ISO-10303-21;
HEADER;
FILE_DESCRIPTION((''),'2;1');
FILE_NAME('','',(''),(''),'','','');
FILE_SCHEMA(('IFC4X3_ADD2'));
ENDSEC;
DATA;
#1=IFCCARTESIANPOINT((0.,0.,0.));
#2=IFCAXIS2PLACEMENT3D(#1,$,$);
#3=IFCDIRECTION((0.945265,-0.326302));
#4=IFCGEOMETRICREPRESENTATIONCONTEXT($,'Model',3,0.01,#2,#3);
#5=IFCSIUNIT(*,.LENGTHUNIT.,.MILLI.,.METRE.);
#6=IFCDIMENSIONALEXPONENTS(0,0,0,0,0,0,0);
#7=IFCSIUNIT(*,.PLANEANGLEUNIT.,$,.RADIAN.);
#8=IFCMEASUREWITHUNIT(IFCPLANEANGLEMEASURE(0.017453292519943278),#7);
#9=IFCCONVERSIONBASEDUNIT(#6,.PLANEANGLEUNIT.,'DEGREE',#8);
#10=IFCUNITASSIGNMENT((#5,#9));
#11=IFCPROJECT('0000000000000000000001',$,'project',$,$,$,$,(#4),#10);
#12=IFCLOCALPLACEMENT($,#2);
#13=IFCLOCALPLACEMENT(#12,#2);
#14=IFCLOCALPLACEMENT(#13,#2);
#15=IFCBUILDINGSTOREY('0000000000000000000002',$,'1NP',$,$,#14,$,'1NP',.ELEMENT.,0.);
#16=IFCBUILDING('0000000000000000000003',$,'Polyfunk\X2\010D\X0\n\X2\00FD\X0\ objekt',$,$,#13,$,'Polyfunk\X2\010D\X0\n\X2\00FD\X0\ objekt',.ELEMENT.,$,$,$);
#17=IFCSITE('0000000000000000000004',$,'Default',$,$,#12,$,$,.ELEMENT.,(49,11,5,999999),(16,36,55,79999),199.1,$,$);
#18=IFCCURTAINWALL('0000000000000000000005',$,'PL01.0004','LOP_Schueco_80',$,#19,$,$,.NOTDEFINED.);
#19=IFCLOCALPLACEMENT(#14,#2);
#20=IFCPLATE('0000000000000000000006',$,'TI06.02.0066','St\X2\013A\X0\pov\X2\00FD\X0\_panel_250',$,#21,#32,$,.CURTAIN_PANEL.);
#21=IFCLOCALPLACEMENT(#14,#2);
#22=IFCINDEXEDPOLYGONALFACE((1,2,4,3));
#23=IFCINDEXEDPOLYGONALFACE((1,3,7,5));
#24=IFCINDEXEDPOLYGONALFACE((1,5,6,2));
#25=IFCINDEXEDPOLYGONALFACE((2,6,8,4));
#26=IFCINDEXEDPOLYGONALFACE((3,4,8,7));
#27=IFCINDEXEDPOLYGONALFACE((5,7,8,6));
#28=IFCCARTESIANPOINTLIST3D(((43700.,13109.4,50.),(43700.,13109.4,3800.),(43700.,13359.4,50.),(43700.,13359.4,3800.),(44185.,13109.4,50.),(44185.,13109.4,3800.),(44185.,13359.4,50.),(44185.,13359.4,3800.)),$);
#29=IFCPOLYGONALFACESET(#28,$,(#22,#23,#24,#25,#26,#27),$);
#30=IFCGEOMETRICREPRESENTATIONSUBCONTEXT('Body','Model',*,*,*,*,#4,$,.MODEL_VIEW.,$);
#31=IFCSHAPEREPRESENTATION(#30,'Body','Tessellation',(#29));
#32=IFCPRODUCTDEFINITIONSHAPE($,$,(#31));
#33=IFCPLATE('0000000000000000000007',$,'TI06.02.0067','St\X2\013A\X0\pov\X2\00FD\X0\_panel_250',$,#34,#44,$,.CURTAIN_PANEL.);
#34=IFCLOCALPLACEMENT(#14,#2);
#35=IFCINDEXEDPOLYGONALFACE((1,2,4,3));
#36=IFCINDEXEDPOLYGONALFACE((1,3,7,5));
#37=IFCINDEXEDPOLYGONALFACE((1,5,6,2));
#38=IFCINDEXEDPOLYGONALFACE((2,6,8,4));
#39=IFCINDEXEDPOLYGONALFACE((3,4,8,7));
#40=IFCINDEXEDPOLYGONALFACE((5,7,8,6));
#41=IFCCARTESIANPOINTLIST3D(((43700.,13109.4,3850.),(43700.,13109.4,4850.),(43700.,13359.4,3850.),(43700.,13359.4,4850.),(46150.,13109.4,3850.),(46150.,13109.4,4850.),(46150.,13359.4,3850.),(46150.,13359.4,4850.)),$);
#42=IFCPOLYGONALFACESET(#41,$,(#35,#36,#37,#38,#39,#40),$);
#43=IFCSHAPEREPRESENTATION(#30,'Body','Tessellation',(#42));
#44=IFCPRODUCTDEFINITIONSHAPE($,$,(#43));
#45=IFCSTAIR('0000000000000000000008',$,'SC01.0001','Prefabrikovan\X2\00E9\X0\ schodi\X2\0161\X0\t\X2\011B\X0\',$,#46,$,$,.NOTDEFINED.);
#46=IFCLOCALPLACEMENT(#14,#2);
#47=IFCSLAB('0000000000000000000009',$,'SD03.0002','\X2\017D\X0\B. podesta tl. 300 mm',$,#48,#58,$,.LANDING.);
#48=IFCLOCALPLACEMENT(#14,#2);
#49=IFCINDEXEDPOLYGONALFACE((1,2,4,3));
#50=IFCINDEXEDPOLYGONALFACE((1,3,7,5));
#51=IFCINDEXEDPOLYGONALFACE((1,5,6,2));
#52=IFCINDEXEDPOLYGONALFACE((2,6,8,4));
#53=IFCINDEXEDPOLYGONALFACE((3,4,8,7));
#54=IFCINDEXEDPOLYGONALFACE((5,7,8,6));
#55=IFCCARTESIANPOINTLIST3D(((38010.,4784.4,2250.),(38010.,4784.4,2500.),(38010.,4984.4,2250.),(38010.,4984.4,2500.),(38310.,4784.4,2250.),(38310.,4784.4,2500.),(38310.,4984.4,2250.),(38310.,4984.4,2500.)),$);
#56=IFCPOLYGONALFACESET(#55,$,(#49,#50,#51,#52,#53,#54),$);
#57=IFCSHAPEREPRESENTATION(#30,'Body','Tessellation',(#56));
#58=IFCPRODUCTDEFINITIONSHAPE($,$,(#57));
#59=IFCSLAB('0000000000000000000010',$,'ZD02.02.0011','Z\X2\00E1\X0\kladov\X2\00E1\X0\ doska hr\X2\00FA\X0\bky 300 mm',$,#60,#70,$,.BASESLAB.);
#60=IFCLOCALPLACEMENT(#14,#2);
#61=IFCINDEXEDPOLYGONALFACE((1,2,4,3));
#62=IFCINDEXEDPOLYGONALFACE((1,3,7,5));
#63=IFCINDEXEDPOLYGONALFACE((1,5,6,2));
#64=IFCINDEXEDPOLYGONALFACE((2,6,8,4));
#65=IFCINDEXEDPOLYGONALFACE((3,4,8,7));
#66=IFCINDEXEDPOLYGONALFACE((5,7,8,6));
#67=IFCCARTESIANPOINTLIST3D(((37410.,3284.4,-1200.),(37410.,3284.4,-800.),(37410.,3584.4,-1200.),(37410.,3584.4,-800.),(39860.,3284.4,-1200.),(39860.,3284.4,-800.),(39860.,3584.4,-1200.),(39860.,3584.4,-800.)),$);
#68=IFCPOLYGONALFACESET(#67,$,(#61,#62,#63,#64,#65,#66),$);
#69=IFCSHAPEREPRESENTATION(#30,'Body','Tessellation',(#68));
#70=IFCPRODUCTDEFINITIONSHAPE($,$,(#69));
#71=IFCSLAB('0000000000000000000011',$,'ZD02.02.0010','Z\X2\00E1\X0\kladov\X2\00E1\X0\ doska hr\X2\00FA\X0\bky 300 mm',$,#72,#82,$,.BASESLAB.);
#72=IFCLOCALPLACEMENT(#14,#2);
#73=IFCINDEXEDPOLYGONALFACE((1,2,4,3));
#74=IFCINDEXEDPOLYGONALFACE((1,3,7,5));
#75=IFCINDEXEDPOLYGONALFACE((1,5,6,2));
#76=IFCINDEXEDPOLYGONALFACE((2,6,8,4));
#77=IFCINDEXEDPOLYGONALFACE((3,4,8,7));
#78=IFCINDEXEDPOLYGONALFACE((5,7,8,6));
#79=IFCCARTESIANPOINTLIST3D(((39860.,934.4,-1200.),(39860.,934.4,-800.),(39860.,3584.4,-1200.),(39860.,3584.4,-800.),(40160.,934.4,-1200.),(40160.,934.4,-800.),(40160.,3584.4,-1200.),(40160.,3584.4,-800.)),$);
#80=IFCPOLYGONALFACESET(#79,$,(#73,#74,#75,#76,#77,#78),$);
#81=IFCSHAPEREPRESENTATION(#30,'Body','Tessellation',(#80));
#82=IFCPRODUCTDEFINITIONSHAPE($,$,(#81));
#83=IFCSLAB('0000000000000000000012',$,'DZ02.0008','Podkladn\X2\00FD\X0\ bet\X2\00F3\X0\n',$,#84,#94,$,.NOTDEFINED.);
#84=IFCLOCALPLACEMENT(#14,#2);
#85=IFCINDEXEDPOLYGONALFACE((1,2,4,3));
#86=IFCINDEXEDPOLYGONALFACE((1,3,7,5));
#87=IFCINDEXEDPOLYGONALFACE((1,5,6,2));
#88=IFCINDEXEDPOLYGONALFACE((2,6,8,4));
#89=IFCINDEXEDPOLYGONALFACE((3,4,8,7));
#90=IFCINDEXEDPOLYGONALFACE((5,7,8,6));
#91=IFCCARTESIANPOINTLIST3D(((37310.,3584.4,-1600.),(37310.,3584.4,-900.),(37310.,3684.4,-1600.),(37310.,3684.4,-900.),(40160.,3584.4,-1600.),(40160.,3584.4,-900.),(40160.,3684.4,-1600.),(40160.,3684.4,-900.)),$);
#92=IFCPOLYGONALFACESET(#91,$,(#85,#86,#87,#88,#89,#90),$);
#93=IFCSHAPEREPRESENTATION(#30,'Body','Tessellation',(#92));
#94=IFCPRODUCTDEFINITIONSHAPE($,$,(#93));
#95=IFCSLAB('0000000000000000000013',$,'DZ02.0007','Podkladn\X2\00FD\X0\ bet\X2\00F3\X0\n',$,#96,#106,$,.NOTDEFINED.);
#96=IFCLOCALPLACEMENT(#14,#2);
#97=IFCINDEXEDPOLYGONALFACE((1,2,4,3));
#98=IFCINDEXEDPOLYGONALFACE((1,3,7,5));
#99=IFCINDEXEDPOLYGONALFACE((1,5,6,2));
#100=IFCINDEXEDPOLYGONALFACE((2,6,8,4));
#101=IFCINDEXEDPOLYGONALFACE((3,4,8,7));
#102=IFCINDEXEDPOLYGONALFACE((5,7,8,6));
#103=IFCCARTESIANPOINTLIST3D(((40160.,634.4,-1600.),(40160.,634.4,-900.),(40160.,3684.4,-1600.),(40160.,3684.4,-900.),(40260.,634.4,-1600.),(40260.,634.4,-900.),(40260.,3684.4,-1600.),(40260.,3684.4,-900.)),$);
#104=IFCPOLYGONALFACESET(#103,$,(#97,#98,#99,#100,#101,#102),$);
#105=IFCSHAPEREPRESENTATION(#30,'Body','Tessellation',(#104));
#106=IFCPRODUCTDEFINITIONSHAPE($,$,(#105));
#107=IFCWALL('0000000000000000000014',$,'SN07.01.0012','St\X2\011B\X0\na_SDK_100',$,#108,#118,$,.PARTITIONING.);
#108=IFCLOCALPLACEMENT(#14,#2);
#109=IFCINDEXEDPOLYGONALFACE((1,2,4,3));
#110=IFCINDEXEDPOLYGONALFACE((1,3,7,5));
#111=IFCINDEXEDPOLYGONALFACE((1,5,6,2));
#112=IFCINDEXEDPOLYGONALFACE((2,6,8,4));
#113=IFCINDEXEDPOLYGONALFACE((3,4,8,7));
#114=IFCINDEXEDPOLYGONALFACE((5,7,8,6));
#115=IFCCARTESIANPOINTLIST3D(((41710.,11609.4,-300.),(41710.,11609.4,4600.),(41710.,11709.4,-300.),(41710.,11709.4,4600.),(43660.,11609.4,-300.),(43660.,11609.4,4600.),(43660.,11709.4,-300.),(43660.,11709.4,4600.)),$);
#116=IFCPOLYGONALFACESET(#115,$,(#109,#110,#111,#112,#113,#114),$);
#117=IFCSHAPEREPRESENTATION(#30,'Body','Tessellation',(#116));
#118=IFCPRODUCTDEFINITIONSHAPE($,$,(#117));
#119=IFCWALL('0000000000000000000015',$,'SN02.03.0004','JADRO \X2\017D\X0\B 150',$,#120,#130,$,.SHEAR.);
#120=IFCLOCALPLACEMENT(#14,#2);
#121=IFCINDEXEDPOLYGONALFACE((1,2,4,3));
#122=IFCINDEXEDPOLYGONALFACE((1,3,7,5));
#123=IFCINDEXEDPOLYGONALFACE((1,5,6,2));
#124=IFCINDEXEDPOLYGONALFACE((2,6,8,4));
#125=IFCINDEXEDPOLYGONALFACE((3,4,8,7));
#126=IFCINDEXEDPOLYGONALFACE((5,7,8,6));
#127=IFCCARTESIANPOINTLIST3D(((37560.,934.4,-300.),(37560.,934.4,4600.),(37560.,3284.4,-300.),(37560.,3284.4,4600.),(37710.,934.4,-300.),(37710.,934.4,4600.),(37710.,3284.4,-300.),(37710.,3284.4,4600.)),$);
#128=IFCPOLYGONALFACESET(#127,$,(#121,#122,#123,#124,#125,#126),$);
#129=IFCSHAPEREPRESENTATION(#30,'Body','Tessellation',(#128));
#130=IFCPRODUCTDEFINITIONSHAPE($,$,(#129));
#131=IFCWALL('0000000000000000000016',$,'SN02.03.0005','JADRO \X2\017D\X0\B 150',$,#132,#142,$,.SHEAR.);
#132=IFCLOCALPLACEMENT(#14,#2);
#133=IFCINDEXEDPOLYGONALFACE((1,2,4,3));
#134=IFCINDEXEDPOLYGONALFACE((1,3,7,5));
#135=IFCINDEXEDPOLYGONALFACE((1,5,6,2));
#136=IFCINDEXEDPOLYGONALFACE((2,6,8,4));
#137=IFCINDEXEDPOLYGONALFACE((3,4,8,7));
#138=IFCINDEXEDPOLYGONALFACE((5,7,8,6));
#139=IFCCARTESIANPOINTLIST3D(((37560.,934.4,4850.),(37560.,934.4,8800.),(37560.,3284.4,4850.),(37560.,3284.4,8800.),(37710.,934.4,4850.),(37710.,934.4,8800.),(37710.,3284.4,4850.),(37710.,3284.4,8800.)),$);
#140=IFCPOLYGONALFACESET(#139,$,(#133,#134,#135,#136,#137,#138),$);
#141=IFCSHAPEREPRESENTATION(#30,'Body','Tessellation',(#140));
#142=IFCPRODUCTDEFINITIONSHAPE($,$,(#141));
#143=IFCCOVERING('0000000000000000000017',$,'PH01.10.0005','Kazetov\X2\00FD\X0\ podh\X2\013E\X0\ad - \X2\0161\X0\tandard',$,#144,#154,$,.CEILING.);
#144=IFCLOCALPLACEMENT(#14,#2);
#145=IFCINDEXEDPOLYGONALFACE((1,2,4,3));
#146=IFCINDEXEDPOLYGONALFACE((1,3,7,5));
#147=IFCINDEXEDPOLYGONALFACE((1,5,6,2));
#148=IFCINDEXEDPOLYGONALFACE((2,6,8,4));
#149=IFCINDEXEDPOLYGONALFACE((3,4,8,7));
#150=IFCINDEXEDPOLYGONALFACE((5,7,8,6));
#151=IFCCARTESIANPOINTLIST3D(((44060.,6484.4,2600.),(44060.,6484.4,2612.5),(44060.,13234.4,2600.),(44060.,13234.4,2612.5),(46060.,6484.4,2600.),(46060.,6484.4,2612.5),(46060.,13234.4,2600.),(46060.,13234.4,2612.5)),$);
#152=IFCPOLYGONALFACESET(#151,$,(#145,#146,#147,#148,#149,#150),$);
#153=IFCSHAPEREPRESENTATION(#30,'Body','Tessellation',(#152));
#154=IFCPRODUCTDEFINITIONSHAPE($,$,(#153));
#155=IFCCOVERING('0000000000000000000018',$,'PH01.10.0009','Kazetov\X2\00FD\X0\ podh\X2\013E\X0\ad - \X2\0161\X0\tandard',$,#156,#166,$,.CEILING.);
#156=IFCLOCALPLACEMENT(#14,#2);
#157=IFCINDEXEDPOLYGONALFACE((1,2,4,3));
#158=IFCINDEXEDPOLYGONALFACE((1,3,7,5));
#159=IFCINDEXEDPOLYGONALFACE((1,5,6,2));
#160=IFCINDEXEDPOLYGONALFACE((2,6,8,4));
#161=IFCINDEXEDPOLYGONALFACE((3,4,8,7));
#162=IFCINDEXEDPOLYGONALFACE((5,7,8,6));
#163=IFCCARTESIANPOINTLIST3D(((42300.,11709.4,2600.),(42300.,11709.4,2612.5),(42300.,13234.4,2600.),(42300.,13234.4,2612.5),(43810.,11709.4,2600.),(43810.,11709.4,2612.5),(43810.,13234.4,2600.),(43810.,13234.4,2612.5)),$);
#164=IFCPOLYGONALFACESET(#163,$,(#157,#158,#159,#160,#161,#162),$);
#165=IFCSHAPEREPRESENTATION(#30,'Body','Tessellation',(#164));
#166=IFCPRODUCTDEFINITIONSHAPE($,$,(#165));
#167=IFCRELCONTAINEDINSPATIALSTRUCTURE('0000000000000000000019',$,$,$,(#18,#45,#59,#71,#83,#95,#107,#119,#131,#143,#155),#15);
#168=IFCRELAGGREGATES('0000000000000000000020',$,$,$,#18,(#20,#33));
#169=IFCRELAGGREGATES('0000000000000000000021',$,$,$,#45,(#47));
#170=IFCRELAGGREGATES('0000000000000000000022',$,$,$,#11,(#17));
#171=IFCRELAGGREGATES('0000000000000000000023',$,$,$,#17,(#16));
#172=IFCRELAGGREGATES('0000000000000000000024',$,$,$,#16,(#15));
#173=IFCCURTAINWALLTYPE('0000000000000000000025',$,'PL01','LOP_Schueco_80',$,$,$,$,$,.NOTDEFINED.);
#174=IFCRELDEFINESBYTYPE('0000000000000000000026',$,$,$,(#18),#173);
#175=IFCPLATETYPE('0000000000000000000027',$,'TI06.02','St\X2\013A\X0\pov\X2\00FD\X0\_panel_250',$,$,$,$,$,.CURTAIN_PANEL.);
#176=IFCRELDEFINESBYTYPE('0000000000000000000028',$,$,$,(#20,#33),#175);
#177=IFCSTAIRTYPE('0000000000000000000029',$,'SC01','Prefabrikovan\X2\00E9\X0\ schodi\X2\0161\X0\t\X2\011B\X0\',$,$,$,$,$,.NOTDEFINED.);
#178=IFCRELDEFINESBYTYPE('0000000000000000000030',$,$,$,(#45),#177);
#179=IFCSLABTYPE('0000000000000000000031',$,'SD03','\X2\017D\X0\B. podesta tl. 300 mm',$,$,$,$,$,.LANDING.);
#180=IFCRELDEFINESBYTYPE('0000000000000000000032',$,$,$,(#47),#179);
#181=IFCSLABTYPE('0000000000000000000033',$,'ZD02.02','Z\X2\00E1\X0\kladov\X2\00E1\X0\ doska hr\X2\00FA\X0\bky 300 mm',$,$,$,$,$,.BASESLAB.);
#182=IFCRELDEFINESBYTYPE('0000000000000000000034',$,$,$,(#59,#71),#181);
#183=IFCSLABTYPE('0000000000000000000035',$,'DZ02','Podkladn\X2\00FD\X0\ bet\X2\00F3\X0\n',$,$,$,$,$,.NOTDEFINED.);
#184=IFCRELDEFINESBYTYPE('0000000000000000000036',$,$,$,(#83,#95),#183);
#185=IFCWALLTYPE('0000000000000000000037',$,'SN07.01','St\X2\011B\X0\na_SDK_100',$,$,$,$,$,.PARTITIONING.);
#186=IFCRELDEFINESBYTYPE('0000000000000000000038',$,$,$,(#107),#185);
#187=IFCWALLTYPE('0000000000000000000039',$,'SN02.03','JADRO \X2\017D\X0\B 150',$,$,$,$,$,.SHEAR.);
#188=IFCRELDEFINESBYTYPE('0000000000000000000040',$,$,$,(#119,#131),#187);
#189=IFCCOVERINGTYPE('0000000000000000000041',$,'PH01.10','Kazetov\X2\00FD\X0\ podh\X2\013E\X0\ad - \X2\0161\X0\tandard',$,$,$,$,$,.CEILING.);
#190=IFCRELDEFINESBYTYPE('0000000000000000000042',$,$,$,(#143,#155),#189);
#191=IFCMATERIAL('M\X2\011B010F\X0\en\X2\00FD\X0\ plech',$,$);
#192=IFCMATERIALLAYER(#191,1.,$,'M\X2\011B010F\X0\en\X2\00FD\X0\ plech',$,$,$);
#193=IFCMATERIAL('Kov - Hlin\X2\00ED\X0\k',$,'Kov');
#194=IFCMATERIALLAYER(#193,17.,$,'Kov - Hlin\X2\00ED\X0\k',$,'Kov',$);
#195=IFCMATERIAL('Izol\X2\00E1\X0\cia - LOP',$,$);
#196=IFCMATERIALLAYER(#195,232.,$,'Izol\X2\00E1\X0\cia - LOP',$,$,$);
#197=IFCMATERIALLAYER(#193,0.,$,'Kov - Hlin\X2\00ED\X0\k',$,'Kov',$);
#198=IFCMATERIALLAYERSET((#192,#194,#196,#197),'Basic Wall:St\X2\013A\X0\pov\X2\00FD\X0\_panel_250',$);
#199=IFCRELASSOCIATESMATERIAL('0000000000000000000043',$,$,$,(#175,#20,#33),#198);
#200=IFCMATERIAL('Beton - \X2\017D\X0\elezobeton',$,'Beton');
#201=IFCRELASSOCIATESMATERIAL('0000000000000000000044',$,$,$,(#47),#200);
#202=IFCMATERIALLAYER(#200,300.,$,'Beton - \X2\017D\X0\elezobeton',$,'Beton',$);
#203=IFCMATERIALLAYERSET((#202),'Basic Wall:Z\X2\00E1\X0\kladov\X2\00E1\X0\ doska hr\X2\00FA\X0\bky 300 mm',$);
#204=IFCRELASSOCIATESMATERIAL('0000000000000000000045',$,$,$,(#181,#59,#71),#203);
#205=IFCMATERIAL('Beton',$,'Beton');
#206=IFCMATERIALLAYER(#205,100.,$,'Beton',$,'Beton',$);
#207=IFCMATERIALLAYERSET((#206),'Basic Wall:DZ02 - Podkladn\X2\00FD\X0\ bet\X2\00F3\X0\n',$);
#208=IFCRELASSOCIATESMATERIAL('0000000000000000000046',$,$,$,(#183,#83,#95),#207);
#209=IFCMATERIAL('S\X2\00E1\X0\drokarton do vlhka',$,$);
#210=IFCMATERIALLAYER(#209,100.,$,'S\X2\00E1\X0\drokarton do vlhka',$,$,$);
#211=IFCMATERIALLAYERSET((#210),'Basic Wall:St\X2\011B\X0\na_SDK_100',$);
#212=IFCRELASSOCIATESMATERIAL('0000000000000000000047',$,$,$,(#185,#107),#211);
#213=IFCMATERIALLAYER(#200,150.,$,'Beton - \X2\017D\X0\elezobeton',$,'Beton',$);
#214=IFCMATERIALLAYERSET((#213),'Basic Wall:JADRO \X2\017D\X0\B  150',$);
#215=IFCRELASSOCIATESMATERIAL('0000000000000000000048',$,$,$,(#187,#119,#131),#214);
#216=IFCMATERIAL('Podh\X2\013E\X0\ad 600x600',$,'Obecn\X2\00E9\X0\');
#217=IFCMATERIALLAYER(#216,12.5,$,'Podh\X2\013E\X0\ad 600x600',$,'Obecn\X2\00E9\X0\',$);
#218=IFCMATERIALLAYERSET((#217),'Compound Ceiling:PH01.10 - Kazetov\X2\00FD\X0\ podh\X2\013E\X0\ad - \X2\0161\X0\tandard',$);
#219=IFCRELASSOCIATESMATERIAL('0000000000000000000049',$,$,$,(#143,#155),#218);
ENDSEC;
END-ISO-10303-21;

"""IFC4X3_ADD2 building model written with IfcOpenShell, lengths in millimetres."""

from ifc_helpers import new_model, entity, si_unit, converted_unit, direction, frame, frame_2d, origin, place, context, subcontext, project, spatial, polyline, rectangle, extrude, clip, bounded_halfspace, material, layer, layer_set, layer_usage, type_object, element, aggregate, save


model = new_model("IFC4X3_ADD2")

# Units and contexts
model_context = context("Model", 3, precision=0.01, world=origin(), true_north=direction((0.945265, -0.326302)))
body_context = subcontext(model_context, "Body", "Model", "MODEL_VIEW")
ifc_project = project(units=[si_unit("LENGTHUNIT", "METRE", prefix="MILLI"), converted_unit("PLANEANGLEUNIT", "DEGREE", entity("IfcPlaneAngleMeasure", 0.017453292519943278), si_unit("PLANEANGLEUNIT", "RADIAN"), dimensions=[0, 0, 0, 0, 0, 0, 0])], contexts=[model_context])

# Site, building, storey
site_placement = place(None, origin())
site = spatial("IfcSite", under=ifc_project, at=site_placement, Name="Default", CompositionType="ELEMENT", RefLatitude=(49, 11, 5, 999999), RefLongitude=(16, 36, 55, 79999), RefElevation=199.1)
building_placement = place(site_placement, origin())
building = spatial("IfcBuilding", under=site, at=building_placement, Name="Polyfunkčný objekt", LongName="Polyfunkčný objekt", CompositionType="ELEMENT")
storey_placement = place(building_placement, origin())
storey = spatial("IfcBuildingStorey", under=building, at=storey_placement, Name="1NP", LongName="1NP", CompositionType="ELEMENT", Elevation=0.0)

# Curtain wall, plates
curtain_wall_type = type_object("IfcCurtainWallType", Name="PL01", Description="LOP_Schueco_80", PredefinedType="NOTDEFINED")
curtain_wall_placement = place(storey_placement, origin())
curtain_wall = element("IfcCurtainWall", 1, at=curtain_wall_placement, inside=storey, type_object=curtain_wall_type, Name="PL01.0004", Description="LOP_Schueco_80", PredefinedType="NOTDEFINED")
ifc_material_1 = material(Name="Měďený plech")
ifc_layer_1 = layer(ifc_material_1, 1.0, Name="Měďený plech")
ifc_material_2 = material(Name="Kov - Hliník", Category="Kov")
ifc_layer_2 = layer(ifc_material_2, 17.0, Name="Kov - Hliník", Category="Kov")
ifc_material_3 = material(Name="Izolácia - LOP")
ifc_layer_3 = layer(ifc_material_3, 232.0, Name="Izolácia - LOP")
ifc_layer_4 = layer(ifc_material_2, 0.0, Name="Kov - Hliník", Category="Kov")
ifc_layer_set_1 = layer_set([ifc_layer_1, ifc_layer_2, ifc_layer_3, ifc_layer_4], Name="Basic Wall:Stĺpový_panel_250")
ifc_layer_usage_1 = layer_usage(ifc_layer_set_1, "AXIS2", "NEGATIVE", 125.0)
plate_type = type_object("IfcPlateType", Name="TI06.02", Description="Stĺpový_panel_250", PredefinedType="CURTAIN_PANEL", material=ifc_layer_set_1)
plate_1_placement = place(storey_placement, frame((43700.0, 13234.4, 50.0)))
plate_1 = element("IfcPlate", 2, at=plate_1_placement, type_object=plate_type, material=ifc_layer_usage_1, Name="TI06.02.0066", Description="Stĺpový_panel_250", PredefinedType="CURTAIN_PANEL", context=body_context, shape_type="SweptSolid", body=[
    extrude(rectangle(XDim=250.0, YDim=485.0, at=frame_2d((0.0, 0.0), x_axis=(1.0, 0.0))), frame((242.5, 0.0, 0.0), z_axis=(0.0, 0.0, 1.0), x_axis=(0.0, 1.0, 0.0)), (0.0, 0.0, 1.0), 3750.0),
])
ifc_layer_usage_2 = layer_usage(ifc_layer_set_1, "AXIS2", "NEGATIVE", 125.0)
plate_2_placement = place(storey_placement, frame((43700.0, 13234.4, 3850.0)))
plate_2 = element("IfcPlate", 3, at=plate_2_placement, type_object=plate_type, material=ifc_layer_usage_2, Name="TI06.02.0067", Description="Stĺpový_panel_250", PredefinedType="CURTAIN_PANEL", context=body_context, shape_type="SweptSolid", body=[
    extrude(rectangle(XDim=250.0, YDim=2450.0, at=frame_2d((0.0, 0.0), x_axis=(1.0, 0.0))), frame((1225.0, 0.0, 0.0), z_axis=(0.0, 0.0, 1.0), x_axis=(0.0, 1.0, 0.0)), (0.0, 0.0, 1.0), 1000.0),
])
aggregate(curtain_wall, [plate_1, plate_2])

# Stair, slab
stair_type = type_object("IfcStairType", Name="SC01", Description="Prefabrikované schodiště", PredefinedType="NOTDEFINED")
stair_placement = place(storey_placement, origin())
stair = element("IfcStair", 4, at=stair_placement, inside=storey, type_object=stair_type, Name="SC01.0001", Description="Prefabrikované schodiště", PredefinedType="NOTDEFINED")
ifc_material_4 = material(Name="Beton - Železobeton", Category="Beton")
slab_type_1 = type_object("IfcSlabType", Name="SD03", Description="ŽB. podesta tl. 300 mm", PredefinedType="LANDING")
slab_1_placement = place(stair_placement, frame((38010.0, 4784.4, 0.0)))
slab_1 = element("IfcSlab", 5, at=slab_1_placement, type_object=slab_type_1, material=ifc_material_4, Name="SD03.0002", Description="ŽB. podesta tl. 300 mm", PredefinedType="LANDING", context=body_context, shape_type="SweptSolid", body=[
    extrude(rectangle(XDim=200.0, YDim=300.0, at=frame_2d((0.0, 0.0), x_axis=(1.0, 0.0))), frame((150.0, 100.0, 2250.0), z_axis=(0.0, 0.0, 1.0), x_axis=(0.0, 1.0, 0.0)), (0.0, 0.0, 1.0), 250.0),
])
aggregate(stair, [slab_1])

# Slabs
ifc_layer_5 = layer(ifc_material_4, 300.0, Name="Beton - Železobeton", Category="Beton")
ifc_layer_set_2 = layer_set([ifc_layer_5], Name="Basic Wall:Základová doska hrúbky 300 mm")
slab_type_2 = type_object("IfcSlabType", Name="ZD02.02", Description="Základová doska hrúbky 300 mm", PredefinedType="BASESLAB", material=ifc_layer_set_2)
slab_2_placement = place(storey_placement, frame((37410.0, 3434.4, -1200.0)))
element("IfcSlab", 6, at=slab_2_placement, inside=storey, type_object=slab_type_2, material=ifc_layer_set_2, Name="ZD02.02.0011", Description="Základová doska hrúbky 300 mm", PredefinedType="BASESLAB", context=body_context, shape_type="SweptSolid", body=[
    extrude(rectangle(XDim=2450.0, YDim=300.0, at=frame_2d((1225.0, 0.0), x_axis=(-1.0, 0.0))), origin(), (0.0, 0.0, 1.0), 400.0),
])
slab_3_placement = place(storey_placement, frame((40010.0, 3584.4, -1200.0), z_axis=(0.0, 0.0, 1.0), x_axis=(0.0, -1.0, 0.0)))
element("IfcSlab", 7, at=slab_3_placement, inside=storey, type_object=slab_type_2, material=ifc_layer_set_2, Name="ZD02.02.0010", Description="Základová doska hrúbky 300 mm", PredefinedType="BASESLAB", context=body_context, shape_type="SweptSolid", body=[
    extrude(rectangle(XDim=2650.0, YDim=300.0, at=frame_2d((1325.0, 0.0), x_axis=(-1.0, 0.0))), origin(), (0.0, 0.0, 1.0), 400.0),
])
ifc_material_5 = material(Name="Beton", Category="Beton")
ifc_layer_6 = layer(ifc_material_5, 100.0, Name="Beton", Category="Beton")
ifc_layer_set_3 = layer_set([ifc_layer_6], Name="Basic Wall:DZ02 - Podkladný betón")
slab_type_3 = type_object("IfcSlabType", Name="DZ02", Description="Podkladný betón", PredefinedType="NOTDEFINED", material=ifc_layer_set_3)
slab_4_placement = place(storey_placement, frame((37310.0, 3634.4, -1600.0)))
element("IfcSlab", 8, at=slab_4_placement, inside=storey, type_object=slab_type_3, material=ifc_layer_set_3, Name="DZ02.0008", Description="Podkladný betón", PredefinedType="NOTDEFINED", context=body_context, shape_type="SweptSolid", body=[
    extrude(rectangle(XDim=2850.0, YDim=100.0, at=frame_2d((1425.0, 0.0), x_axis=(-1.0, 0.0))), origin(), (0.0, 0.0, 1.0), 700.0),
])
slab_5_placement = place(storey_placement, frame((40210.0, 3684.4, -1600.0), z_axis=(0.0, 0.0, 1.0), x_axis=(0.0, -1.0, 0.0)))
element("IfcSlab", 9, at=slab_5_placement, inside=storey, type_object=slab_type_3, material=ifc_layer_set_3, Name="DZ02.0007", Description="Podkladný betón", PredefinedType="NOTDEFINED", context=body_context, shape_type="SweptSolid", body=[
    extrude(rectangle(XDim=3050.0, YDim=100.0, at=frame_2d((1525.0, 0.0), x_axis=(-1.0, 0.0))), origin(), (0.0, 0.0, 1.0), 700.0),
])

# Walls
ifc_material_6 = material(Name="Sádrokarton do vlhka")
ifc_layer_7 = layer(ifc_material_6, 100.0, Name="Sádrokarton do vlhka")
ifc_layer_set_4 = layer_set([ifc_layer_7], Name="Basic Wall:Stěna_SDK_100")
wall_type_1 = type_object("IfcWallType", Name="SN07.01", Description="Stěna_SDK_100", PredefinedType="PARTITIONING", material=ifc_layer_set_4)
wall_1_placement = place(storey_placement, frame((41710.0, 11659.4, -300.0)))
element("IfcWall", 10, at=wall_1_placement, inside=storey, type_object=wall_type_1, material=ifc_layer_set_4, Name="SN07.01.0012", Description="Stěna_SDK_100", PredefinedType="PARTITIONING", context=body_context, shape_type="Clipping", body=[
    clip(clip(extrude(rectangle(XDim=1950.0, YDim=100.0, at=frame_2d((975.0, 0.0), x_axis=(-1.0, 0.0))), origin(), (0.0, 0.0, 1.0), 4900.0), bounded_halfspace(frame((0.0, -50.0, 4900.0), z_axis=(0.0, 0.0, -1.0), x_axis=(1.0, 0.0, 0.0)), True, frame((0.0, -50.0, 4900.0)), polyline([(0.0, 0.0), (900.0, 0.0), (1050.0, 0.0), (1950.0, 0.0), (1950.0, 100.0), (0.0, 100.0), (0.0, 0.0)]))), bounded_halfspace(frame((1950.0, -50.0, 0.0), z_axis=(0.0, 0.0, 1.0), x_axis=(0.0, 1.0, 0.0)), True, frame((1950.0, -50.0, 0.0)), polyline([(0.0, 0.0), (0.0, 100.0), (-1950.0, 100.0), (-1950.0, 0.0), (-1050.0, 0.0), (-900.0, 0.0), (0.0, 0.0)]))),
])
ifc_layer_8 = layer(ifc_material_4, 150.0, Name="Beton - Železobeton", Category="Beton")
ifc_layer_set_5 = layer_set([ifc_layer_8], Name="Basic Wall:JADRO ŽB  150")
wall_type_2 = type_object("IfcWallType", Name="SN02.03", Description="JADRO ŽB 150", PredefinedType="SHEAR", material=ifc_layer_set_5)
wall_2_placement = place(storey_placement, frame((37635.0, 3284.4, -300.0), z_axis=(0.0, 0.0, 1.0), x_axis=(0.0, -1.0, 0.0)))
element("IfcWall", 11, at=wall_2_placement, inside=storey, type_object=wall_type_2, material=ifc_layer_set_5, Name="SN02.03.0004", Description="JADRO ŽB 150", PredefinedType="SHEAR", context=body_context, shape_type="SweptSolid", body=[
    extrude(rectangle(XDim=2350.0, YDim=150.0, at=frame_2d((1175.0, 0.0), x_axis=(-1.0, 0.0))), origin(), (0.0, 0.0, 1.0), 4900.0),
])
wall_3_placement = place(storey_placement, frame((37635.0, 3284.4, 4850.0), z_axis=(0.0, 0.0, 1.0), x_axis=(0.0, -1.0, 0.0)))
element("IfcWall", 12, at=wall_3_placement, inside=storey, type_object=wall_type_2, material=ifc_layer_set_5, Name="SN02.03.0005", Description="JADRO ŽB 150", PredefinedType="SHEAR", context=body_context, shape_type="SweptSolid", body=[
    extrude(rectangle(XDim=2350.0, YDim=150.0, at=frame_2d((1175.0, 0.0), x_axis=(-1.0, 0.0))), origin(), (0.0, 0.0, 1.0), 3950.0),
])

# Coverings
ifc_material_7 = material(Name="Podhľad 600x600", Category="Obecné")
ifc_layer_9 = layer(ifc_material_7, 12.5, Name="Podhľad 600x600", Category="Obecné")
ifc_layer_set_6 = layer_set([ifc_layer_9], Name="Compound Ceiling:PH01.10 - Kazetový podhľad - štandard")
ifc_layer_usage_3 = layer_usage(ifc_layer_set_6, "AXIS3", "NEGATIVE", 0.0)
covering_type_1 = type_object("IfcCoveringType", Name="PH01.10", Description="Kazetový podhľad - štandard", PredefinedType="CEILING")
covering_1_placement = place(storey_placement, frame((44060.0, 6484.4, 2600.0)))
element("IfcCovering", 13, at=covering_1_placement, inside=storey, type_object=covering_type_1, material=ifc_layer_usage_3, Name="PH01.10.0005", Description="Kazetový podhľad - štandard", PredefinedType="CEILING", context=body_context, shape_type="SweptSolid", body=[
    extrude(rectangle(XDim=2000.0, YDim=6750.0, at=frame_2d((0.0, 0.0), x_axis=(1.0, 0.0))), frame((1000.0, 3375.0, 0.0), z_axis=(0.0, 0.0, 1.0), x_axis=(-1.0, 0.0, 0.0)), (0.0, 0.0, 1.0), 12.5),
])
ifc_layer_usage_4 = layer_usage(ifc_layer_set_6, "AXIS3", "NEGATIVE", 0.0)
covering_2_placement = place(storey_placement, frame((42300.0, 11709.4, 2600.0)))
element("IfcCovering", 14, at=covering_2_placement, inside=storey, type_object=covering_type_1, material=ifc_layer_usage_4, Name="PH01.10.0009", Description="Kazetový podhľad - štandard", PredefinedType="CEILING", context=body_context, shape_type="SweptSolid", body=[
    extrude(rectangle(XDim=1510.0, YDim=1525.0, at=frame_2d((0.0, 0.0), x_axis=(1.0, 0.0))), frame((755.0, 762.5, 0.0), z_axis=(0.0, 0.0, 1.0), x_axis=(-1.0, 0.0, 0.0)), (0.0, 0.0, 1.0), 12.5),
])

save(model, "model.ifc")
